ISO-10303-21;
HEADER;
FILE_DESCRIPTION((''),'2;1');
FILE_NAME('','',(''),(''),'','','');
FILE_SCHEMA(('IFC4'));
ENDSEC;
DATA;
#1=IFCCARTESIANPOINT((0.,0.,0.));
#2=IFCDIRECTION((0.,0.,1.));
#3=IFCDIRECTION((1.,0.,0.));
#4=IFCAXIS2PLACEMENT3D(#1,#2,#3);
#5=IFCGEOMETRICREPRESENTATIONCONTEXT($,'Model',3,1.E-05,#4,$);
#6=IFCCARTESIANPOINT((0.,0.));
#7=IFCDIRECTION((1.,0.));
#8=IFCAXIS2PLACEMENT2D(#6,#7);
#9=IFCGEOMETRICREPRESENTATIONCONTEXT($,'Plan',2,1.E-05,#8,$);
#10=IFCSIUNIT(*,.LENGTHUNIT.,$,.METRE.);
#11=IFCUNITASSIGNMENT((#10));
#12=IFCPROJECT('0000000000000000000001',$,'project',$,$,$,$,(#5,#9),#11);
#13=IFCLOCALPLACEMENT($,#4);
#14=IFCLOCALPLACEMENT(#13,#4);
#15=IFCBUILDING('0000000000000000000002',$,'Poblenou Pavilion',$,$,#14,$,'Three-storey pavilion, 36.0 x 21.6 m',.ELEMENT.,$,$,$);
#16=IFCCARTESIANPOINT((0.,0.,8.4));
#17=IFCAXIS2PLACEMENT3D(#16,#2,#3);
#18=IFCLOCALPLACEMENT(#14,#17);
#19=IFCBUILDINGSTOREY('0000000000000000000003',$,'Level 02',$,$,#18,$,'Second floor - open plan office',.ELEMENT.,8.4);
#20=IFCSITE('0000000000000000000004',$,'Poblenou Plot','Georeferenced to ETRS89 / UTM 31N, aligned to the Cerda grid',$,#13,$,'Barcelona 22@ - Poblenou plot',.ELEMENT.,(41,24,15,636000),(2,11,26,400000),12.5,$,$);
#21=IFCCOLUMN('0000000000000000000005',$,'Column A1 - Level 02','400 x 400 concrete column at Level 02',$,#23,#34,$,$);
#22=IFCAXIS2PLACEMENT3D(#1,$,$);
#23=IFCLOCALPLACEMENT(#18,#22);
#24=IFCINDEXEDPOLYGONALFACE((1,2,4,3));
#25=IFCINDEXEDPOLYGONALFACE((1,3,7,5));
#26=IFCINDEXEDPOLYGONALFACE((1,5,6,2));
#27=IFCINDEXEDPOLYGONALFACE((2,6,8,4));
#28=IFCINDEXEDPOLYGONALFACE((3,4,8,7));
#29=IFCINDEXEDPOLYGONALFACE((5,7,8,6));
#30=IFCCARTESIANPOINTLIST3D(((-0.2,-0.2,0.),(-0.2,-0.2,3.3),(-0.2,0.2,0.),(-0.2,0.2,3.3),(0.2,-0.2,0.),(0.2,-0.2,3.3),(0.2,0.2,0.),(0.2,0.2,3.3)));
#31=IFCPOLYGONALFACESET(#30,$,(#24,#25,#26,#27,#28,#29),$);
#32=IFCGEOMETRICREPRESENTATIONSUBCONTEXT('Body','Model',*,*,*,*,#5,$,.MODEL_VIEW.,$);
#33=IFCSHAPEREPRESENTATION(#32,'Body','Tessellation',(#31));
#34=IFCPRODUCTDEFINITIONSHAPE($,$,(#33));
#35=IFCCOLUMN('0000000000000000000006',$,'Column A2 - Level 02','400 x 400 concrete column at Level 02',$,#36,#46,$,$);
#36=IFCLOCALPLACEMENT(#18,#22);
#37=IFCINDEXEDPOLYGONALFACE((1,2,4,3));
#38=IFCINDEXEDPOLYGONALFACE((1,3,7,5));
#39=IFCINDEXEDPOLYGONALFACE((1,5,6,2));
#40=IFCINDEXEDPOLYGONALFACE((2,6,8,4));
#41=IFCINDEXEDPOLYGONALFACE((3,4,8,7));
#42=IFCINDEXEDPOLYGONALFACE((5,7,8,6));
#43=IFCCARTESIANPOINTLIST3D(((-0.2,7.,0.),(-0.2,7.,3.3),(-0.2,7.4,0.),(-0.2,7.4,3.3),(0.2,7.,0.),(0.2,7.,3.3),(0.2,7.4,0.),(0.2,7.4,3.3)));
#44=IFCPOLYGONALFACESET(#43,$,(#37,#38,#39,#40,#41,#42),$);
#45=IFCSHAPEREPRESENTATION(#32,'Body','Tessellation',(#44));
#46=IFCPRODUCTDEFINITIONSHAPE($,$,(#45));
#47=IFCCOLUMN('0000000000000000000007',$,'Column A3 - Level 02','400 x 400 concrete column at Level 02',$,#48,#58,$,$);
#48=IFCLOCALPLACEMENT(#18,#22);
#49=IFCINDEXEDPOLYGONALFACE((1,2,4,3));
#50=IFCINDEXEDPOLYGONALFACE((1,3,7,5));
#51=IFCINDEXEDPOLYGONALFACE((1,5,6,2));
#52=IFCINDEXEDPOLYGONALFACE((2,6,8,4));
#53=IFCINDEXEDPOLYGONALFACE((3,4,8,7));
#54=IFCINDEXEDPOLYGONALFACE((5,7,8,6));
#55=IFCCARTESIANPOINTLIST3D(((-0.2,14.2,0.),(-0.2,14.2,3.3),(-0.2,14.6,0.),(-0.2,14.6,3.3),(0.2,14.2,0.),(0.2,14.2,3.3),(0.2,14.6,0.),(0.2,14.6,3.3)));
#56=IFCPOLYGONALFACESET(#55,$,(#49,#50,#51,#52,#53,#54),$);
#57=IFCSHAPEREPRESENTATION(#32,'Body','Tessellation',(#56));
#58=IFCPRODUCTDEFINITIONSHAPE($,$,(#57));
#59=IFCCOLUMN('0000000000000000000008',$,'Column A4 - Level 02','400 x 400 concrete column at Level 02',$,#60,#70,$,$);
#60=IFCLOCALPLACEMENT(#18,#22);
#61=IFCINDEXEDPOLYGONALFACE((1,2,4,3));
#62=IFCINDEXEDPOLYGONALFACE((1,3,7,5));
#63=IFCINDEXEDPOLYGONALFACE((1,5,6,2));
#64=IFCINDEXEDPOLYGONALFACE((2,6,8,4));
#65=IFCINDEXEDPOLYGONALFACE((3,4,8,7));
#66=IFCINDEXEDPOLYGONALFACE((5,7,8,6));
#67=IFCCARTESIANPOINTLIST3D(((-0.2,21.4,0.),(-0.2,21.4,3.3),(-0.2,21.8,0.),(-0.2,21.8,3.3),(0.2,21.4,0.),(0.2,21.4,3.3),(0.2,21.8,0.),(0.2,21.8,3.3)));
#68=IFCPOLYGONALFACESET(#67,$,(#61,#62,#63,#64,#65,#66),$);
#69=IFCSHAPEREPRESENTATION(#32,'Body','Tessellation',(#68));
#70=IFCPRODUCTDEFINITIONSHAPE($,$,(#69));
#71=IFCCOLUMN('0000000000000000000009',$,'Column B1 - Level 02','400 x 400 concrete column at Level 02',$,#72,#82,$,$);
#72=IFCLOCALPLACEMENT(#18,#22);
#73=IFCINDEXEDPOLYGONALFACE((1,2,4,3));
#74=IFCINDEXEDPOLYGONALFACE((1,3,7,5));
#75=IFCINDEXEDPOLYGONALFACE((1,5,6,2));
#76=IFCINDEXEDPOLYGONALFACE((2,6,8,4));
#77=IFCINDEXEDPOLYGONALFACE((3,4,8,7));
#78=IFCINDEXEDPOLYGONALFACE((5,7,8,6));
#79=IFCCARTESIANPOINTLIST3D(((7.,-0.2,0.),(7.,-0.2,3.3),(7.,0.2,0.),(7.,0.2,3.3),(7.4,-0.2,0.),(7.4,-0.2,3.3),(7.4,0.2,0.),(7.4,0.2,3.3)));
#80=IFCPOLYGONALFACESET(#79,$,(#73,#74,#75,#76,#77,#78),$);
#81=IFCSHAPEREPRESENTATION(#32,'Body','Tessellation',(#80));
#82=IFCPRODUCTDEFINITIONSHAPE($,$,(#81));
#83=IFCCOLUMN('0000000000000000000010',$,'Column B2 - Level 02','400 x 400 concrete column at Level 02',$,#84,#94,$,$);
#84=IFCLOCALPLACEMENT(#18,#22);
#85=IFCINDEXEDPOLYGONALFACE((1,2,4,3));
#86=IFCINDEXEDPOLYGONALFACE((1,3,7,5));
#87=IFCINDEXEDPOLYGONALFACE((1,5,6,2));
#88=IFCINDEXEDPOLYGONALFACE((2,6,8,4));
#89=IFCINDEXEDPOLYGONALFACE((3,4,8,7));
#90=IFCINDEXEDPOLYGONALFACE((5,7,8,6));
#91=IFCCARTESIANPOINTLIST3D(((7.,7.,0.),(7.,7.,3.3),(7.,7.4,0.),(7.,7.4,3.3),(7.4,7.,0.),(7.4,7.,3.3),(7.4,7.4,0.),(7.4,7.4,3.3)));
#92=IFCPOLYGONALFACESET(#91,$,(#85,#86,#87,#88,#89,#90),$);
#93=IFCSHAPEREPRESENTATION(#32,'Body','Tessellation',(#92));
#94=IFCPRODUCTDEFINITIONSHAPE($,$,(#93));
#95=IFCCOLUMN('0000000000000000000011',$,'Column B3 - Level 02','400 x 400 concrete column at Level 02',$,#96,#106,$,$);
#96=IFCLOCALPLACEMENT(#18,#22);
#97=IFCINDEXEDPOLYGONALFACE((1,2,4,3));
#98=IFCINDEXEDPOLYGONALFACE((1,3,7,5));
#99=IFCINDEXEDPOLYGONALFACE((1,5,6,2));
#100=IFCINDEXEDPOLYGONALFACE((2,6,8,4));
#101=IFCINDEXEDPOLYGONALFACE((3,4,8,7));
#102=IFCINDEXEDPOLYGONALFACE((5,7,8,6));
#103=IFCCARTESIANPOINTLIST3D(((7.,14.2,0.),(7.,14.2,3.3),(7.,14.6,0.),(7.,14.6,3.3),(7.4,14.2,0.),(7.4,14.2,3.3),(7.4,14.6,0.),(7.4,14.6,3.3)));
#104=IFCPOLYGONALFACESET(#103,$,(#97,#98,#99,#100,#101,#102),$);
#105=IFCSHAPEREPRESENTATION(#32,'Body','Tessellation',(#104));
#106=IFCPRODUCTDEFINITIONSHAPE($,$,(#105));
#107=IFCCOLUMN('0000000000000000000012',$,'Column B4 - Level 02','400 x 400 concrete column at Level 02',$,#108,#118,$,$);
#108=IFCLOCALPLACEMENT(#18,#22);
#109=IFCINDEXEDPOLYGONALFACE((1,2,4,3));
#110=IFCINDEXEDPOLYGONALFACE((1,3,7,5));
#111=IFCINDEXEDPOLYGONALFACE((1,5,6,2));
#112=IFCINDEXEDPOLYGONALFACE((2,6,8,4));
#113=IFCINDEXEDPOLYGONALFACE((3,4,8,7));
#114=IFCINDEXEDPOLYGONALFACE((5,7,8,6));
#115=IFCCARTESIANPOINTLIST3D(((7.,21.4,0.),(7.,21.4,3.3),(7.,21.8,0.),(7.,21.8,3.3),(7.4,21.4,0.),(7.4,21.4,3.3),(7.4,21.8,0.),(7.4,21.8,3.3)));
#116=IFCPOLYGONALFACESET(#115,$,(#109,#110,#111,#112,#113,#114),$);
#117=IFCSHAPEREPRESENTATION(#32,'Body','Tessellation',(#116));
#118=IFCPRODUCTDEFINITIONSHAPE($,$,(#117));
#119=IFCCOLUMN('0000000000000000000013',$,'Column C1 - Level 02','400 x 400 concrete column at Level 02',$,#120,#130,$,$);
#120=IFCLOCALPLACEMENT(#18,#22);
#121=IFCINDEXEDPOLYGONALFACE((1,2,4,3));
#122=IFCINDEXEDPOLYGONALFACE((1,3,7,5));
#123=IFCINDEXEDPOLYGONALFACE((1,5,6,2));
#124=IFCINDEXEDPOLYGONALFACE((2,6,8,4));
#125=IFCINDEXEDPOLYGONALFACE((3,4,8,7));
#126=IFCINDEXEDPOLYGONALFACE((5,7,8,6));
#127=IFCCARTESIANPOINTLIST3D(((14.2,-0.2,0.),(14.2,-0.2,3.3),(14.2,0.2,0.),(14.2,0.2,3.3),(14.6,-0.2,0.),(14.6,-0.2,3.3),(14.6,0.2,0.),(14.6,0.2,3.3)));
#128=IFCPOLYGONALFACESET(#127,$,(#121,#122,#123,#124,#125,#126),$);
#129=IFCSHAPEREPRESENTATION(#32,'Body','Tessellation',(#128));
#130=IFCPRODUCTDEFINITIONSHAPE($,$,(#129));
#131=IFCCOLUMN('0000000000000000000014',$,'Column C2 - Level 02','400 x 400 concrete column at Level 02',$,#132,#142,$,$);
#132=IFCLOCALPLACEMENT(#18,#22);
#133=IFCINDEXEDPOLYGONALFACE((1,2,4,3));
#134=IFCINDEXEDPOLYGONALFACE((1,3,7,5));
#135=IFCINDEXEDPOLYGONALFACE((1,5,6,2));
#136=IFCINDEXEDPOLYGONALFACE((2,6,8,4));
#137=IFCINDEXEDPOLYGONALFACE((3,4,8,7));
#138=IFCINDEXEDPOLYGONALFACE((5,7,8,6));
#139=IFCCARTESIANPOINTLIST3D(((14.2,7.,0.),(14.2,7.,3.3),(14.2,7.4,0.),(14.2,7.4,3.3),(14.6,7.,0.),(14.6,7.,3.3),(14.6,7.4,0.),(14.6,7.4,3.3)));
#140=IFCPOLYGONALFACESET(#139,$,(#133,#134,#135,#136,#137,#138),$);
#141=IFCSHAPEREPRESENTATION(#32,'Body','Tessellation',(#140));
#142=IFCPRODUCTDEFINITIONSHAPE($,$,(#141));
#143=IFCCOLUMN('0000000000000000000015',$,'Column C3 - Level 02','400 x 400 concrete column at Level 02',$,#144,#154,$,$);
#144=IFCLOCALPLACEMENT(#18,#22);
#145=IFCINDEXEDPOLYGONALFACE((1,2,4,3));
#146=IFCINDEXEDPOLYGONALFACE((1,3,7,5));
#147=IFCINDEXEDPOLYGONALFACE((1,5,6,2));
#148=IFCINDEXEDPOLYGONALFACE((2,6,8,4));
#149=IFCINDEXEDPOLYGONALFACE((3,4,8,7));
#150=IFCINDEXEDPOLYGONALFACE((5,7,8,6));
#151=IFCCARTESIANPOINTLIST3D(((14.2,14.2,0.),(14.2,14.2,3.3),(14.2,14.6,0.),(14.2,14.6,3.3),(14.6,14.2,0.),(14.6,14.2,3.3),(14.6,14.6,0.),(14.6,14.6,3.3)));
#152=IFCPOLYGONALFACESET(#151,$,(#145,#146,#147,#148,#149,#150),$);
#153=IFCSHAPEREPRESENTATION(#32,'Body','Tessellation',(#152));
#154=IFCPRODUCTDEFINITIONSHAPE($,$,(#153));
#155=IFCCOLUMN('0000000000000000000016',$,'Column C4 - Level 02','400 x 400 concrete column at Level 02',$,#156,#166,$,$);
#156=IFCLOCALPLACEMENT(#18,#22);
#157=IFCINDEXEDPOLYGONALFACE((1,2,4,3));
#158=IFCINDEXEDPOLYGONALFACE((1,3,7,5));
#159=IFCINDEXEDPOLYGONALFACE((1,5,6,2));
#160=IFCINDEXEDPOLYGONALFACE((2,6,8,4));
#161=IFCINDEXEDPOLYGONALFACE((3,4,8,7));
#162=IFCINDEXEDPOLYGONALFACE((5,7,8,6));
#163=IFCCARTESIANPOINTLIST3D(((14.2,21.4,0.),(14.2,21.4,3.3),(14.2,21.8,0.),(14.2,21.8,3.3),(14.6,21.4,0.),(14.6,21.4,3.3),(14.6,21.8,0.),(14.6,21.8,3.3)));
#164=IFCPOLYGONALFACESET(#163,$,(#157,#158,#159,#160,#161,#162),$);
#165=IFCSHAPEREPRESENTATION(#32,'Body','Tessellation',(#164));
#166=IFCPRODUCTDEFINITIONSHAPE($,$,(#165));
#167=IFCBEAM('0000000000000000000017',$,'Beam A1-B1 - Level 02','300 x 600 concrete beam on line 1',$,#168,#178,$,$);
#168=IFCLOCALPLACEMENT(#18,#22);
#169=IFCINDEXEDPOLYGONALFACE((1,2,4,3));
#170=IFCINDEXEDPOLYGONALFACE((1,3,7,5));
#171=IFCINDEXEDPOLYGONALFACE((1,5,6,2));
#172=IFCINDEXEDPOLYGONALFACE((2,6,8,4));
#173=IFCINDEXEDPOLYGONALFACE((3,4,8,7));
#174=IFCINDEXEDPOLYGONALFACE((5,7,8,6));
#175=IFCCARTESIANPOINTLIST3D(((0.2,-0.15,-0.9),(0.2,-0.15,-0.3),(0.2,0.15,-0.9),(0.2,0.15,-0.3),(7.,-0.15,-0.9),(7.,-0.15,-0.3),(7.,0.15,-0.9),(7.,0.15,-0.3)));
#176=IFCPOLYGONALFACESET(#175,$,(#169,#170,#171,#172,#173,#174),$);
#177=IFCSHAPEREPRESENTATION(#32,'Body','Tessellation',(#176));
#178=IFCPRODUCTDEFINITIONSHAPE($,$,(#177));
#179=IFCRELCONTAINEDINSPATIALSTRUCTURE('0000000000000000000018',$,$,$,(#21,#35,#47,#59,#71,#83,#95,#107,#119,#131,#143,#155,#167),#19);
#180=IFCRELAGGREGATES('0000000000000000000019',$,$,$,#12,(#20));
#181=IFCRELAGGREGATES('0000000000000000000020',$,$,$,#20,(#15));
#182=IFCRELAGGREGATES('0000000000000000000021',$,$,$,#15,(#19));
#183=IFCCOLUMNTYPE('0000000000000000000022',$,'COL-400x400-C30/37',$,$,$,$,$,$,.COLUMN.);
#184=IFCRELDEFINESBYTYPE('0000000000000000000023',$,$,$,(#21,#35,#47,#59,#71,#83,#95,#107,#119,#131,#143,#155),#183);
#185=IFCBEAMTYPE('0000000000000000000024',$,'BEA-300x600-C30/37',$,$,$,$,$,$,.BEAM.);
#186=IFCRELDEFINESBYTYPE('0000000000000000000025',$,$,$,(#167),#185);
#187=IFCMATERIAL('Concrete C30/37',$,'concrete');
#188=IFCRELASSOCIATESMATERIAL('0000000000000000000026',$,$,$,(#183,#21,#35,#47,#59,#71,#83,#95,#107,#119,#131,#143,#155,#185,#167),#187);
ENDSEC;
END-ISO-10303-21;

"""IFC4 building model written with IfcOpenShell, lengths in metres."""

from ifc_helpers import new_model, si_unit, frame, origin_with_axes, origin_2d_with_axis, place, context, subcontext, project, spatial, line, indexed_curve, rectangle, outline, extrude, material, material_profile, profile_set, profile_usage, type_object, element, save


model = new_model("IFC4")

# Units and contexts
model_context = context("Model", 3, precision=1e-05, world=origin_with_axes())
plan_context = context("Plan", 2, precision=1e-05, world=origin_2d_with_axis())
body_context = subcontext(model_context, "Body", "Model", "MODEL_VIEW")
ifc_project = project(units=[si_unit("LENGTHUNIT", "METRE")], contexts=[model_context, plan_context])

# Site, building, storey
site_placement = place(None, origin_with_axes())
site = spatial("IfcSite", under=ifc_project, at=site_placement, Name="Poblenou Plot", Description="Georeferenced to ETRS89 / UTM 31N, aligned to the Cerda grid", LongName="Barcelona 22@ - Poblenou plot", CompositionType="ELEMENT", RefLatitude=(41, 24, 15, 636000), RefLongitude=(2, 11, 26, 400000), RefElevation=12.5)
building_placement = place(site_placement, origin_with_axes())
building = spatial("IfcBuilding", under=site, at=building_placement, Name="Poblenou Pavilion", LongName="Three-storey pavilion, 36.0 x 21.6 m", CompositionType="ELEMENT")
storey_placement = place(building_placement, frame((0.0, 0.0, 8.4), z_axis=(0.0, 0.0, 1.0), x_axis=(1.0, 0.0, 0.0)))
storey = spatial("IfcBuildingStorey", under=building, at=storey_placement, Name="Level 02", LongName="Second floor - open plan office", CompositionType="ELEMENT", Elevation=8.4)

# Columns
ifc_material = material(Name="Concrete C30/37", Category="concrete")
ifc_material_profile_1 = material_profile(ifc_material, rectangle(XDim=0.4, YDim=0.4))
ifc_profile_set_1 = profile_set([ifc_material_profile_1], Name="COL-400x400-C30/37")
ifc_profile_usage_1 = profile_usage(ifc_profile_set_1)
column_type = type_object("IfcColumnType", Name="COL-400x400-C30/37", PredefinedType="COLUMN", material=ifc_profile_set_1)
column_1_placement = place(storey_placement, frame((-0.2, -0.2, 0.0), z_axis=(0.0, 0.0, 1.0), x_axis=(1.0, 0.0, 0.0)))
element("IfcColumn", 1, at=column_1_placement, inside=storey, type_object=column_type, material=ifc_profile_usage_1, Name="Column A1 - Level 02", Description="400 x 400 concrete column at Level 02", context=body_context, shape_type="SweptSolid", body=[
    extrude(outline(indexed_curve([(0.0, 0.0), (0.4, 0.0), (0.4, 0.4), (0.0, 0.4)], segments=[line(1, 2, 3, 4, 1)])), origin_with_axes(), (0.0, 0.0, 1.0), 3.3),
])
ifc_profile_usage_2 = profile_usage(ifc_profile_set_1)
column_2_placement = place(storey_placement, frame((-0.2, 7.0, 0.0), z_axis=(0.0, 0.0, 1.0), x_axis=(1.0, 0.0, 0.0)))
element("IfcColumn", 2, at=column_2_placement, inside=storey, type_object=column_type, material=ifc_profile_usage_2, Name="Column A2 - Level 02", Description="400 x 400 concrete column at Level 02", context=body_context, shape_type="SweptSolid", body=[
    extrude(outline(indexed_curve([(0.0, 0.0), (0.4, 0.0), (0.4, 0.4), (0.0, 0.4)], segments=[line(1, 2, 3, 4, 1)])), origin_with_axes(), (0.0, 0.0, 1.0), 3.3),
])
ifc_profile_usage_3 = profile_usage(ifc_profile_set_1)
column_3_placement = place(storey_placement, frame((-0.2, 14.2, 0.0), z_axis=(0.0, 0.0, 1.0), x_axis=(1.0, 0.0, 0.0)))
element("IfcColumn", 3, at=column_3_placement, inside=storey, type_object=column_type, material=ifc_profile_usage_3, Name="Column A3 - Level 02", Description="400 x 400 concrete column at Level 02", context=body_context, shape_type="SweptSolid", body=[
    extrude(outline(indexed_curve([(0.0, 0.0), (0.4, 0.0), (0.4, 0.4), (0.0, 0.4)], segments=[line(1, 2, 3, 4, 1)])), origin_with_axes(), (0.0, 0.0, 1.0), 3.3),
])
ifc_profile_usage_4 = profile_usage(ifc_profile_set_1)
column_4_placement = place(storey_placement, frame((-0.2, 21.4, 0.0), z_axis=(0.0, 0.0, 1.0), x_axis=(1.0, 0.0, 0.0)))
element("IfcColumn", 4, at=column_4_placement, inside=storey, type_object=column_type, material=ifc_profile_usage_4, Name="Column A4 - Level 02", Description="400 x 400 concrete column at Level 02", context=body_context, shape_type="SweptSolid", body=[
    extrude(outline(indexed_curve([(0.0, 0.0), (0.4, 0.0), (0.4, 0.4), (0.0, 0.4)], segments=[line(1, 2, 3, 4, 1)])), origin_with_axes(), (0.0, 0.0, 1.0), 3.3),
])
ifc_profile_usage_5 = profile_usage(ifc_profile_set_1)
column_5_placement = place(storey_placement, frame((7.0, -0.2, 0.0), z_axis=(0.0, 0.0, 1.0), x_axis=(1.0, 0.0, 0.0)))
element("IfcColumn", 5, at=column_5_placement, inside=storey, type_object=column_type, material=ifc_profile_usage_5, Name="Column B1 - Level 02", Description="400 x 400 concrete column at Level 02", context=body_context, shape_type="SweptSolid", body=[
    extrude(outline(indexed_curve([(0.0, 0.0), (0.4, 0.0), (0.4, 0.4), (0.0, 0.4)], segments=[line(1, 2, 3, 4, 1)])), origin_with_axes(), (0.0, 0.0, 1.0), 3.3),
])
ifc_profile_usage_6 = profile_usage(ifc_profile_set_1)
column_6_placement = place(storey_placement, frame((7.0, 7.0, 0.0), z_axis=(0.0, 0.0, 1.0), x_axis=(1.0, 0.0, 0.0)))
element("IfcColumn", 6, at=column_6_placement, inside=storey, type_object=column_type, material=ifc_profile_usage_6, Name="Column B2 - Level 02", Description="400 x 400 concrete column at Level 02", context=body_context, shape_type="SweptSolid", body=[
    extrude(outline(indexed_curve([(0.0, 0.0), (0.4, 0.0), (0.4, 0.4), (0.0, 0.4)], segments=[line(1, 2, 3, 4, 1)])), origin_with_axes(), (0.0, 0.0, 1.0), 3.3),
])
ifc_profile_usage_7 = profile_usage(ifc_profile_set_1)
column_7_placement = place(storey_placement, frame((7.0, 14.2, 0.0), z_axis=(0.0, 0.0, 1.0), x_axis=(1.0, 0.0, 0.0)))
element("IfcColumn", 7, at=column_7_placement, inside=storey, type_object=column_type, material=ifc_profile_usage_7, Name="Column B3 - Level 02", Description="400 x 400 concrete column at Level 02", context=body_context, shape_type="SweptSolid", body=[
    extrude(outline(indexed_curve([(0.0, 0.0), (0.4, 0.0), (0.4, 0.4), (0.0, 0.4)], segments=[line(1, 2, 3, 4, 1)])), origin_with_axes(), (0.0, 0.0, 1.0), 3.3),
])
ifc_profile_usage_8 = profile_usage(ifc_profile_set_1)
column_8_placement = place(storey_placement, frame((7.0, 21.4, 0.0), z_axis=(0.0, 0.0, 1.0), x_axis=(1.0, 0.0, 0.0)))
element("IfcColumn", 8, at=column_8_placement, inside=storey, type_object=column_type, material=ifc_profile_usage_8, Name="Column B4 - Level 02", Description="400 x 400 concrete column at Level 02", context=body_context, shape_type="SweptSolid", body=[
    extrude(outline(indexed_curve([(0.0, 0.0), (0.4, 0.0), (0.4, 0.4), (0.0, 0.4)], segments=[line(1, 2, 3, 4, 1)])), origin_with_axes(), (0.0, 0.0, 1.0), 3.3),
])
ifc_profile_usage_9 = profile_usage(ifc_profile_set_1)
column_9_placement = place(storey_placement, frame((14.2, -0.2, 0.0), z_axis=(0.0, 0.0, 1.0), x_axis=(1.0, 0.0, 0.0)))
element("IfcColumn", 9, at=column_9_placement, inside=storey, type_object=column_type, material=ifc_profile_usage_9, Name="Column C1 - Level 02", Description="400 x 400 concrete column at Level 02", context=body_context, shape_type="SweptSolid", body=[
    extrude(outline(indexed_curve([(0.0, 0.0), (0.4, 0.0), (0.4, 0.4), (0.0, 0.4)], segments=[line(1, 2, 3, 4, 1)])), origin_with_axes(), (0.0, 0.0, 1.0), 3.3),
])
ifc_profile_usage_10 = profile_usage(ifc_profile_set_1)
column_10_placement = place(storey_placement, frame((14.2, 7.0, 0.0), z_axis=(0.0, 0.0, 1.0), x_axis=(1.0, 0.0, 0.0)))
element("IfcColumn", 10, at=column_10_placement, inside=storey, type_object=column_type, material=ifc_profile_usage_10, Name="Column C2 - Level 02", Description="400 x 400 concrete column at Level 02", context=body_context, shape_type="SweptSolid", body=[
    extrude(outline(indexed_curve([(0.0, 0.0), (0.4, 0.0), (0.4, 0.4), (0.0, 0.4)], segments=[line(1, 2, 3, 4, 1)])), origin_with_axes(), (0.0, 0.0, 1.0), 3.3),
])
ifc_profile_usage_11 = profile_usage(ifc_profile_set_1)
column_11_placement = place(storey_placement, frame((14.2, 14.2, 0.0), z_axis=(0.0, 0.0, 1.0), x_axis=(1.0, 0.0, 0.0)))
element("IfcColumn", 11, at=column_11_placement, inside=storey, type_object=column_type, material=ifc_profile_usage_11, Name="Column C3 - Level 02", Description="400 x 400 concrete column at Level 02", context=body_context, shape_type="SweptSolid", body=[
    extrude(outline(indexed_curve([(0.0, 0.0), (0.4, 0.0), (0.4, 0.4), (0.0, 0.4)], segments=[line(1, 2, 3, 4, 1)])), origin_with_axes(), (0.0, 0.0, 1.0), 3.3),
])
ifc_profile_usage_12 = profile_usage(ifc_profile_set_1)
column_12_placement = place(storey_placement, frame((14.2, 21.4, 0.0), z_axis=(0.0, 0.0, 1.0), x_axis=(1.0, 0.0, 0.0)))
element("IfcColumn", 12, at=column_12_placement, inside=storey, type_object=column_type, material=ifc_profile_usage_12, Name="Column C4 - Level 02", Description="400 x 400 concrete column at Level 02", context=body_context, shape_type="SweptSolid", body=[
    extrude(outline(indexed_curve([(0.0, 0.0), (0.4, 0.0), (0.4, 0.4), (0.0, 0.4)], segments=[line(1, 2, 3, 4, 1)])), origin_with_axes(), (0.0, 0.0, 1.0), 3.3),
])

# Beam
ifc_material_profile_2 = material_profile(ifc_material, rectangle(XDim=0.3, YDim=0.6))
ifc_profile_set_2 = profile_set([ifc_material_profile_2], Name="BEA-300x600-C30/37")
ifc_profile_usage_13 = profile_usage(ifc_profile_set_2)
beam_type = type_object("IfcBeamType", Name="BEA-300x600-C30/37", PredefinedType="BEAM", material=ifc_profile_set_2)
beam_1_placement = place(storey_placement, frame((0.2, -0.15, -0.9), z_axis=(1.0, 0.0, 0.0), x_axis=(0.0, 1.0, 0.0)))
element("IfcBeam", 13, at=beam_1_placement, inside=storey, type_object=beam_type, material=ifc_profile_usage_13, Name="Beam A1-B1 - Level 02", Description="300 x 600 concrete beam on line 1", context=body_context, shape_type="SweptSolid", body=[
    extrude(outline(indexed_curve([(0.0, 0.0), (0.3, 0.0), (0.3, 0.6), (0.0, 0.6)], segments=[line(1, 2, 3, 4, 1)])), origin_with_axes(), (0.0, 0.0, 1.0), 6.8),
])

save(model, "model.ifc")
